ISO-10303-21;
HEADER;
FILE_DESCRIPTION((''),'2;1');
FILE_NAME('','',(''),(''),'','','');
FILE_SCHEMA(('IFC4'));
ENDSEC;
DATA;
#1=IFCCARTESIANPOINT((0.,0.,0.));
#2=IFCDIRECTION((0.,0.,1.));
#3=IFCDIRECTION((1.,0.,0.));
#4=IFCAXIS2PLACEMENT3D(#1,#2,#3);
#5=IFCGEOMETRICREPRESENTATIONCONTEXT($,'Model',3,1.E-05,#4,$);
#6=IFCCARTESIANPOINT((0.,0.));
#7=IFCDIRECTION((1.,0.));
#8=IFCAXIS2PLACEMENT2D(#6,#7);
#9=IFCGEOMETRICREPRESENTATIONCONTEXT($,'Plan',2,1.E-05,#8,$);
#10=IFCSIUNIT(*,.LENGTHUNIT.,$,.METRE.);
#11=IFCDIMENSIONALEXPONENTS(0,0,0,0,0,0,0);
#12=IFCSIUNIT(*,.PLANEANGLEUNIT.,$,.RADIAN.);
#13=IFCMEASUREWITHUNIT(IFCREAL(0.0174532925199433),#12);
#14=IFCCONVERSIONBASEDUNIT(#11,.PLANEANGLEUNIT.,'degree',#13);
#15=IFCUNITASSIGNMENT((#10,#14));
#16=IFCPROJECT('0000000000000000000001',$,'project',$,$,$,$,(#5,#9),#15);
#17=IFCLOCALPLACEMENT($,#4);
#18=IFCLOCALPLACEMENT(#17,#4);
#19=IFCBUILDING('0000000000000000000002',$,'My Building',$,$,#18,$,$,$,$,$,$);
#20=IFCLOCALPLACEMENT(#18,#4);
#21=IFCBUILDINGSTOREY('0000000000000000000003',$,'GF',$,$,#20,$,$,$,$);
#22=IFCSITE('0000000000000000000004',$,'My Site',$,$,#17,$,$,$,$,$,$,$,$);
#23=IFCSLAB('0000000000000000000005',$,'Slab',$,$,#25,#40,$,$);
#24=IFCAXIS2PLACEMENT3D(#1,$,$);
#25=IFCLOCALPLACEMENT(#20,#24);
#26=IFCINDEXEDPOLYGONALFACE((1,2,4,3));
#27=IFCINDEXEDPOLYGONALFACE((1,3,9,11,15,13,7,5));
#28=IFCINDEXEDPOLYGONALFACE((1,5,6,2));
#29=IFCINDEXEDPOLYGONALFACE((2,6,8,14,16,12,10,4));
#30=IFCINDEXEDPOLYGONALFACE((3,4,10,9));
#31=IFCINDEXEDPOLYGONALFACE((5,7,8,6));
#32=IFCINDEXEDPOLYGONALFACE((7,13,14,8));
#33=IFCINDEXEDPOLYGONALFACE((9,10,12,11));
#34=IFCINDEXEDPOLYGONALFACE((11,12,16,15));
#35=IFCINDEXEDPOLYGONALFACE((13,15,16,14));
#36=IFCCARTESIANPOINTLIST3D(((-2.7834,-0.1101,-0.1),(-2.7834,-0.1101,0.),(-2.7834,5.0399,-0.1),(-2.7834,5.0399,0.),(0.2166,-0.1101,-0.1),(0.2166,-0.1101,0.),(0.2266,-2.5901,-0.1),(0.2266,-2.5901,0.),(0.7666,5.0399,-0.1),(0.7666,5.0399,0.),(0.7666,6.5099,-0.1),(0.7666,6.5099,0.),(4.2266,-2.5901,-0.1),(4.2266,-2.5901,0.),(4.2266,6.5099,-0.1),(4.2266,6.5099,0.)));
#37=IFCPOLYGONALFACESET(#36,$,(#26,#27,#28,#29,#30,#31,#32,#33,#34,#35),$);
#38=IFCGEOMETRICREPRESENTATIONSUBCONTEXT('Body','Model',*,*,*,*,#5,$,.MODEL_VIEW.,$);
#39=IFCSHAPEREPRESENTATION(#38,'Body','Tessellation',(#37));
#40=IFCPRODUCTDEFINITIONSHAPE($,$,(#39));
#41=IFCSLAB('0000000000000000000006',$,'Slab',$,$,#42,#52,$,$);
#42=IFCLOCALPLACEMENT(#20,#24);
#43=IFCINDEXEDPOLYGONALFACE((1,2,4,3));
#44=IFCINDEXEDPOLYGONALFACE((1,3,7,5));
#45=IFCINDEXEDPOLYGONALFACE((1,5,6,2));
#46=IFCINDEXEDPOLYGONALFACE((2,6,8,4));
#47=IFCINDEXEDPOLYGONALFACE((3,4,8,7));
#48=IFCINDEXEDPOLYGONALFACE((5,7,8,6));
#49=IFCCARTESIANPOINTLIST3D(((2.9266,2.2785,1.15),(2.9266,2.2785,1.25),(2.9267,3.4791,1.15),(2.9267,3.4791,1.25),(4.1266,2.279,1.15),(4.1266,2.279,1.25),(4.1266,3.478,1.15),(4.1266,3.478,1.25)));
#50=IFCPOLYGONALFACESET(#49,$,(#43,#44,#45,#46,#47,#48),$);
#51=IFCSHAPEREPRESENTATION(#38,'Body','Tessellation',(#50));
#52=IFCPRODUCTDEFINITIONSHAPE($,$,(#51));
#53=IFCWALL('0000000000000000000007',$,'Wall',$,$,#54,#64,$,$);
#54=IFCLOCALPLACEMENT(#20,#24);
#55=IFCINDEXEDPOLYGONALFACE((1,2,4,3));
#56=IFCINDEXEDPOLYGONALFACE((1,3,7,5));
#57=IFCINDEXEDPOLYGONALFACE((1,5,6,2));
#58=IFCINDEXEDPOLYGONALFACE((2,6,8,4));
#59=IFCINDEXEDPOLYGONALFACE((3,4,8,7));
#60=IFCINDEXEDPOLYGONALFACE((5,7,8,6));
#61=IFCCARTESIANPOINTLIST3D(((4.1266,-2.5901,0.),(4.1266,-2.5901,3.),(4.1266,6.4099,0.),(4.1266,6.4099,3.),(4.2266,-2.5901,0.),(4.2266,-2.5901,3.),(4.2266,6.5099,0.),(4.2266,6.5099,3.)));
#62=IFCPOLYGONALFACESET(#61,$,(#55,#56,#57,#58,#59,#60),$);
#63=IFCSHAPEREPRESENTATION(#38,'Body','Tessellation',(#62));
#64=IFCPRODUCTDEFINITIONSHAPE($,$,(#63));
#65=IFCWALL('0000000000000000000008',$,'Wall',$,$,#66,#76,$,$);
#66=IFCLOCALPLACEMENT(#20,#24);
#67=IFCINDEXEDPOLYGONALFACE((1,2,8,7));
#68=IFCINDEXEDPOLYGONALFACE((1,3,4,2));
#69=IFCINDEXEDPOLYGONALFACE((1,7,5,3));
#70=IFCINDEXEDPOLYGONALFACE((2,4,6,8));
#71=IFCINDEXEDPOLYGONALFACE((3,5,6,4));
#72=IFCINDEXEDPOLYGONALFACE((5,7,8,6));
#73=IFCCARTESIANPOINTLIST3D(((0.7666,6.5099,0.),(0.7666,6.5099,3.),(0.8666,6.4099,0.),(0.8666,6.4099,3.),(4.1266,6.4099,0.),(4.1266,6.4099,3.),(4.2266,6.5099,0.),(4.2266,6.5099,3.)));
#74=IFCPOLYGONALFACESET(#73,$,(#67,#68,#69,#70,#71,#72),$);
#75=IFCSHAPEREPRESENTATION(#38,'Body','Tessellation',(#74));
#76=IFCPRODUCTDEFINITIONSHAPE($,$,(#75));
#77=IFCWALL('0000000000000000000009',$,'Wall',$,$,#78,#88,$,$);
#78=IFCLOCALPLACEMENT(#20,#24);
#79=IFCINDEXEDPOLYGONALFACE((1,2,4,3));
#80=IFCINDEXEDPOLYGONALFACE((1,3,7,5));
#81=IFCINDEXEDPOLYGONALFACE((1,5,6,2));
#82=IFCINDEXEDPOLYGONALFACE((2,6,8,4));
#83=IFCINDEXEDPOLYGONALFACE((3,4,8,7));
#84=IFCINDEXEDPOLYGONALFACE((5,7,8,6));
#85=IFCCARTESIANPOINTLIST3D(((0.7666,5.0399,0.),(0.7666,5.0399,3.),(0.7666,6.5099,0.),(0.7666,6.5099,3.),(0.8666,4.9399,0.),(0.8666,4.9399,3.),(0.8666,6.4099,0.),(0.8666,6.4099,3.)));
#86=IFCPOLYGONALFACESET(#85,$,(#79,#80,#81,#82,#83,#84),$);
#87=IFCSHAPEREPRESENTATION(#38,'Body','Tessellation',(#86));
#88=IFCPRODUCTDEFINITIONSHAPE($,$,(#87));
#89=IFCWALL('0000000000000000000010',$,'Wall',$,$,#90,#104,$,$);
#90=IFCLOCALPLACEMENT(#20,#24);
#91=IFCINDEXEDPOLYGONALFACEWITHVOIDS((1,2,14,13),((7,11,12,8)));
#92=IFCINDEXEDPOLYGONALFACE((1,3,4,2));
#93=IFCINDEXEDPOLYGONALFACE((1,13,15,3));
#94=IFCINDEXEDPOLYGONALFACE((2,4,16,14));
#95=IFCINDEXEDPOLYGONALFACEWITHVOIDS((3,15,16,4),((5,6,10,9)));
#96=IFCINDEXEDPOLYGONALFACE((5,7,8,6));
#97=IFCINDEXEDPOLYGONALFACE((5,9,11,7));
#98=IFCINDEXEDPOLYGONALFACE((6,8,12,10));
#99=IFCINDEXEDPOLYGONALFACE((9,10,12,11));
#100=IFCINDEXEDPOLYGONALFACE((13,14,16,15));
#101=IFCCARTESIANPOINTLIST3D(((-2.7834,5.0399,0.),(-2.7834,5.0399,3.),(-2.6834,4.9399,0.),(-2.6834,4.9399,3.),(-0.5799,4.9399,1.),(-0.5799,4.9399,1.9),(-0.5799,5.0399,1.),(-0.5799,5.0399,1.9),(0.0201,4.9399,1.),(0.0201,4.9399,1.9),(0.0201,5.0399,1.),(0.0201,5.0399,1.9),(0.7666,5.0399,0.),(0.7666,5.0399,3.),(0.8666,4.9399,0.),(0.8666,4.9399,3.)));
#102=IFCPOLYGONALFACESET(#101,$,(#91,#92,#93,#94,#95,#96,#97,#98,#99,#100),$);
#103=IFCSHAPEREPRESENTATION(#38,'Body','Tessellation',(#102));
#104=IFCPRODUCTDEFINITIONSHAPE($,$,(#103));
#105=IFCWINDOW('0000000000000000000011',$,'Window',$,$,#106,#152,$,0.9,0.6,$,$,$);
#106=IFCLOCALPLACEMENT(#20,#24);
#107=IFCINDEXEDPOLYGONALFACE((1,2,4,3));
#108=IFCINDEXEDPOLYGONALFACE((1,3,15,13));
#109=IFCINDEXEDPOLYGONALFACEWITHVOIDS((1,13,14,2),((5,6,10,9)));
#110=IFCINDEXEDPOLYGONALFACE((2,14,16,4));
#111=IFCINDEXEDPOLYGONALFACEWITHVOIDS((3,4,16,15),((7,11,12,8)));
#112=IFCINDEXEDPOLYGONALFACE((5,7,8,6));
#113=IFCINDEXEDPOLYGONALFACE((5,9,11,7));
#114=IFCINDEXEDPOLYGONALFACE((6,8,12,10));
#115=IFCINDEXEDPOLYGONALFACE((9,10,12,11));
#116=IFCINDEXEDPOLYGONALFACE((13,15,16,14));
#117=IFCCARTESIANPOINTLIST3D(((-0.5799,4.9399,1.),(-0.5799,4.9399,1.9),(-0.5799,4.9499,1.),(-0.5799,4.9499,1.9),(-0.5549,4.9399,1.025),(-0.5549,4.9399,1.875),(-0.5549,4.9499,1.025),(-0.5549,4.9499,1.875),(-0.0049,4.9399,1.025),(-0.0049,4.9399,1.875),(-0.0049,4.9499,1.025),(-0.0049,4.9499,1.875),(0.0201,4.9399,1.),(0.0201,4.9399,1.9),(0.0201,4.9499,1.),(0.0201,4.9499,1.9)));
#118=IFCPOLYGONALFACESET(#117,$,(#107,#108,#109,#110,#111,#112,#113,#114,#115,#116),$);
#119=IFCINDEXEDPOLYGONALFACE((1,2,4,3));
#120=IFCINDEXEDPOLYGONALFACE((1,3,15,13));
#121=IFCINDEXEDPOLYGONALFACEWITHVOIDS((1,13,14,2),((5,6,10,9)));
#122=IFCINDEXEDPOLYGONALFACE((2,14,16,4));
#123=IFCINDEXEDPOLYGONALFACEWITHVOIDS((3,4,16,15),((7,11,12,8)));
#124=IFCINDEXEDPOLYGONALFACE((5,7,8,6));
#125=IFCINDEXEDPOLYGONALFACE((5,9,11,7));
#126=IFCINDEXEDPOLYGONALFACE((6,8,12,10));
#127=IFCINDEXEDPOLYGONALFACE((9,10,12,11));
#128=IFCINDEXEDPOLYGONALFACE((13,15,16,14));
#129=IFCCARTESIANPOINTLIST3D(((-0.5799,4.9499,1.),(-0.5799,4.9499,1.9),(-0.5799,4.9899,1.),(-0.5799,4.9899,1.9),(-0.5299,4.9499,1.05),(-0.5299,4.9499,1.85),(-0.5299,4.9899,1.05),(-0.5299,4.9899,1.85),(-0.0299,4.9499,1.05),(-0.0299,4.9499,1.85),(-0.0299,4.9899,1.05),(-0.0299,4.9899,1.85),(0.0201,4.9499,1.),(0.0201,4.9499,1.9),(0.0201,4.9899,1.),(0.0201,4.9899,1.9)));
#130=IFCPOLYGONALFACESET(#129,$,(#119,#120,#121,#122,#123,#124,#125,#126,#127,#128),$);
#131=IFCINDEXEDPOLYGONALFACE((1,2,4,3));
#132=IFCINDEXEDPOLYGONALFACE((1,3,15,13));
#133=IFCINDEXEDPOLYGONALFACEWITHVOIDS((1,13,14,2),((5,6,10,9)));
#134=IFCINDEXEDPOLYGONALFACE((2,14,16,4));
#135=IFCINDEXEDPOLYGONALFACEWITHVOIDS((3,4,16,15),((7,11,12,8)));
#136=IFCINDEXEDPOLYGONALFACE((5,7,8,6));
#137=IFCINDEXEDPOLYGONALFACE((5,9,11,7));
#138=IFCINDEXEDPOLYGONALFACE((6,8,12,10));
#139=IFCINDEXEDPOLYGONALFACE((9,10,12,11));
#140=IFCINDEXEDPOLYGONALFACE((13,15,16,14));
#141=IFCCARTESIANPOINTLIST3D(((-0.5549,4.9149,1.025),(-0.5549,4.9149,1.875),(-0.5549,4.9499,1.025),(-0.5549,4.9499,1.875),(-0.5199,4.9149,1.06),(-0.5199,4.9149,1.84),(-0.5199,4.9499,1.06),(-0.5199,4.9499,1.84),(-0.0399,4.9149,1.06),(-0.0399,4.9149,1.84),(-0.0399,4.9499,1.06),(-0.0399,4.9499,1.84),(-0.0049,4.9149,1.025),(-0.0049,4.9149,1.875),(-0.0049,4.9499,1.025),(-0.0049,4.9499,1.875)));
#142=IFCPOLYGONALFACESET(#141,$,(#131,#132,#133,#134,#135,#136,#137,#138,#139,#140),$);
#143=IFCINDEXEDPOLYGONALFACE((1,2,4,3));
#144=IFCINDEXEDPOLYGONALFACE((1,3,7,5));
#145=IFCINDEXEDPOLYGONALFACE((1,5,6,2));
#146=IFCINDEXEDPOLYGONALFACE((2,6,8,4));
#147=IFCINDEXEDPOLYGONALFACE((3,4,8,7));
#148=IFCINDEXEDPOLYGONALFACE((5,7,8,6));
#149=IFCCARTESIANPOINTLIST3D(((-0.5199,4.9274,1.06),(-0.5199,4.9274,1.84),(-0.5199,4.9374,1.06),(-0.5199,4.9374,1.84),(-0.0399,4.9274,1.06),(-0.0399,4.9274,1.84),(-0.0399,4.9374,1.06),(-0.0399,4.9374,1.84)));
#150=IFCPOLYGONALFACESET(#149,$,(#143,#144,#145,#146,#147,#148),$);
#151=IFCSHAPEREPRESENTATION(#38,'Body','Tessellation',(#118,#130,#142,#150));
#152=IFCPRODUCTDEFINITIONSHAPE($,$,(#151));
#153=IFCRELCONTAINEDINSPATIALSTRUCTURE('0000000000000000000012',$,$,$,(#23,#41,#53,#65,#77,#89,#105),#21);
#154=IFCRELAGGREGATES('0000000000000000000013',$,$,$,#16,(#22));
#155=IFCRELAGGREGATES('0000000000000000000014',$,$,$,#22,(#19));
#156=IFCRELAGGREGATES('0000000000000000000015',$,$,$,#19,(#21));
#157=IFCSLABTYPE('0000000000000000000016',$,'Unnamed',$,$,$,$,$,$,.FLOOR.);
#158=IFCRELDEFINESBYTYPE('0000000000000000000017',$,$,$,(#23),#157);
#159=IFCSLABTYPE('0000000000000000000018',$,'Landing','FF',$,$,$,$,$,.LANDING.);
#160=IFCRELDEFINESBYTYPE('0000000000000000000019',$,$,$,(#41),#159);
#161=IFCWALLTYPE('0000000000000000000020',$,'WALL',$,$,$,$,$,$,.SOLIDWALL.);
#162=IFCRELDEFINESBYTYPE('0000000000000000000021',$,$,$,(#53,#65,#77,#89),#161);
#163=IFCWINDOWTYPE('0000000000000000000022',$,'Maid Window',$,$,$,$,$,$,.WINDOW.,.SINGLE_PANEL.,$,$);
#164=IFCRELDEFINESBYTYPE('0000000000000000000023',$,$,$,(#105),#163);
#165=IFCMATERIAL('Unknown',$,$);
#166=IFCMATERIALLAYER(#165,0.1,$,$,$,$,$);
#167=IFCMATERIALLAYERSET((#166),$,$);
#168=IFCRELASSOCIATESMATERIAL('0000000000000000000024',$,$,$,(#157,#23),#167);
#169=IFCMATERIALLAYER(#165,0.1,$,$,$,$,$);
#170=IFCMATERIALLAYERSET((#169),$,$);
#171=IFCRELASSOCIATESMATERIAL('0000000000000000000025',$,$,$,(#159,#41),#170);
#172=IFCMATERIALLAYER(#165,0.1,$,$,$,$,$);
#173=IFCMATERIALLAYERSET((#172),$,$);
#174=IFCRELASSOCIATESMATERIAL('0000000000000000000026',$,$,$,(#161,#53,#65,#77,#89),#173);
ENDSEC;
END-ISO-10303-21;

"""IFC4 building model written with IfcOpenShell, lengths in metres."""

from ifc_helpers import new_model, entity, si_unit, converted_unit, frame, origin_with_axes, origin_2d_with_axis, place, context, subcontext, project, spatial, line, indexed_curve, outline, extrude, shape, source, transform, mapped, material, layer, layer_set, layer_usage, type_object, type_shapes, element, fill, save


model = new_model("IFC4")

# Units and contexts
model_context = context("Model", 3, precision=1e-05, world=origin_with_axes())
plan_context = context("Plan", 2, precision=1e-05, world=origin_2d_with_axis())
body_context_1 = subcontext(model_context, "Body", "Model", "MODEL_VIEW")
body_context_2 = subcontext(plan_context, "Body", "Plan", "PLAN_VIEW")
ifc_project = project(units=[si_unit("LENGTHUNIT", "METRE"), converted_unit("PLANEANGLEUNIT", "degree", entity("IfcReal", 0.0174532925199433), si_unit("PLANEANGLEUNIT", "RADIAN"), dimensions=[0, 0, 0, 0, 0, 0, 0])], contexts=[model_context, plan_context])

# Site, building, storey
site_placement = place(None, origin_with_axes())
site = spatial("IfcSite", under=ifc_project, at=site_placement, Name="My Site")
building_placement = place(site_placement, origin_with_axes())
building = spatial("IfcBuilding", under=site, at=building_placement, Name="My Building")
storey_placement = place(building_placement, origin_with_axes())
storey = spatial("IfcBuildingStorey", under=building, at=storey_placement, Name="GF")

# Slabs
ifc_material_1 = material(Name="Unknown")
ifc_layer_1 = layer(ifc_material_1, 0.1)
ifc_layer_set_1 = layer_set([ifc_layer_1])
ifc_layer_usage_1 = layer_usage(ifc_layer_set_1, "AXIS3", "POSITIVE", -0.1)
slab_type_1 = type_object("IfcSlabType", Name="Unnamed", PredefinedType="FLOOR", material=ifc_layer_set_1)
slab_1_placement = place(storey_placement, frame((4.2266, -2.5901, 0.0), z_axis=(0.0, 0.0, 1.0), x_axis=(1.0, 0.0, 0.0)))
element("IfcSlab", 1, at=slab_1_placement, inside=storey, type_object=slab_type_1, material=ifc_layer_usage_1, Name="Slab", context=body_context_1, shape_type="SweptSolid", body=[
    extrude(outline(indexed_curve([(0.0, 0.0), (0.0, 9.1), (-3.46, 9.1), (-3.46, 7.63), (-7.01, 7.63), (-7.01, 2.48), (-4.01, 2.48), (-4.0, 0.0), (0.0, 0.0)])), frame((0.0, 0.0, -0.1), z_axis=(0.0, 0.0, 1.0), x_axis=(1.0, 0.0, 0.0)), (0.0, 0.0, 1.0), 0.1),
])
ifc_layer_2 = layer(ifc_material_1, 0.1)
ifc_layer_set_2 = layer_set([ifc_layer_2])
ifc_layer_usage_2 = layer_usage(ifc_layer_set_2, "AXIS3", "POSITIVE", -0.1)
slab_type_2 = type_object("IfcSlabType", Name="Landing", Description="FF", PredefinedType="LANDING", material=ifc_layer_set_2)
slab_2_placement = place(storey_placement, frame((2.9266, 2.2785, 1.25), z_axis=(0.0, 0.0, 1.0), x_axis=(1.0, 0.0, 0.0)))
element("IfcSlab", 2, at=slab_2_placement, inside=storey, type_object=slab_type_2, material=ifc_layer_usage_2, Name="Slab", context=body_context_1, shape_type="SweptSolid", body=[
    extrude(outline(indexed_curve([(0.0, 0.0), (1.2, 0.0005), (1.2, 1.1995), (0.0001, 1.2006), (0.0, 0.0)])), frame((0.0, 0.0, -0.1), z_axis=(0.0, 0.0, 1.0), x_axis=(1.0, 0.0, 0.0)), (0.0, 0.0, 1.0), 0.1),
])

# Shared definitions
ifc_layer_3 = layer(ifc_material_1, 0.1)
ifc_layer_set_3 = layer_set([ifc_layer_3])
wall_type = type_object("IfcWallType", Name="WALL", PredefinedType="SOLIDWALL", material=ifc_layer_set_3)

# Walls
ifc_layer_usage_3 = layer_usage(ifc_layer_set_3, "AXIS2", "POSITIVE", 0.0)
wall_1_placement = place(storey_placement, frame((4.2266, -2.5901, 0.0), z_axis=(0.0, 0.0, 1.0), x_axis=(0.0, 1.0, 0.0)))
element("IfcWall", 3, at=wall_1_placement, inside=storey, type_object=wall_type, material=ifc_layer_usage_3, Name="Wall", context=body_context_1, shape_type="SweptSolid", body=[
    extrude(outline(indexed_curve([(0.0, 0.0), (0.0, 0.1), (9.0, 0.1), (9.1, 0.0)], segments=[line(1, 2, 3, 4, 1)])), origin_with_axes(), (0.0, 0.0, 1.0), 3.0),
])
ifc_layer_usage_4 = layer_usage(ifc_layer_set_3, "AXIS2", "POSITIVE", 0.0)
wall_2_placement = place(storey_placement, frame((4.2266, 6.5099, 0.0), z_axis=(0.0, 0.0, 1.0), x_axis=(-1.0, 0.0, 0.0)))
element("IfcWall", 4, at=wall_2_placement, inside=storey, type_object=wall_type, material=ifc_layer_usage_4, Name="Wall", context=body_context_1, shape_type="SweptSolid", body=[
    extrude(outline(indexed_curve([(0.0, 0.0), (0.1, 0.1), (3.36, 0.1), (3.46, 0.0)], segments=[line(1, 2, 3, 4, 1)])), origin_with_axes(), (0.0, 0.0, 1.0), 3.0),
])
ifc_layer_usage_5 = layer_usage(ifc_layer_set_3, "AXIS2", "POSITIVE", 0.0)
wall_3_placement = place(storey_placement, frame((0.7666, 6.5099, 0.0), z_axis=(0.0, 0.0, 1.0), x_axis=(0.0, -1.0, 0.0)))
element("IfcWall", 5, at=wall_3_placement, inside=storey, type_object=wall_type, material=ifc_layer_usage_5, Name="Wall", context=body_context_1, shape_type="SweptSolid", body=[
    extrude(outline(indexed_curve([(0.0, 0.0), (0.1, 0.1), (1.57, 0.1), (1.47, 0.0)], segments=[line(1, 2, 3, 4, 1)])), origin_with_axes(), (0.0, 0.0, 1.0), 3.0),
])

# Wall, opening, window
ifc_layer_usage_6 = layer_usage(ifc_layer_set_3, "AXIS2", "POSITIVE", 0.0)
wall_4_placement = place(storey_placement, frame((0.7666, 5.0399, 0.0), z_axis=(0.0, 0.0, 1.0), x_axis=(-1.0, 0.0, 0.0)))
wall_4 = element("IfcWall", 6, at=wall_4_placement, inside=storey, type_object=wall_type, material=ifc_layer_usage_6, Name="Wall", context=body_context_1, shape_type="SweptSolid", body=[
    extrude(outline(indexed_curve([(0.0, 0.0), (-0.1, 0.1), (3.45, 0.1), (3.55, 0.0)], segments=[line(1, 2, 3, 4, 1)])), origin_with_axes(), (0.0, 0.0, 1.0), 3.0),
])
shared_shape_1 = source(origin_with_axes(), body_context_1, "Body", "SweptSolid", [
    extrude(outline(indexed_curve([(0.0, 0.0), (0.6, 0.0), (0.6, 0.9), (0.0, 0.9)], segments=[line(1, 2, 3, 4, 1)])), frame((0.0, -0.6, 0.0), z_axis=(0.0, -1.0, 0.0), x_axis=(1.0, 0.0, 0.0)), (0.0, 0.0, -1.0), 1.2),
])
opening_1_placement = place(wall_4_placement, frame((0.7465, 0.0, 1.0), z_axis=(0.0, 0.0, 1.0), x_axis=(1.0, 0.0, 0.0)))
opening_1 = element("IfcOpeningElement", 7, at=opening_1_placement, cuts=wall_4, PredefinedType="OPENING", context=body_context_1, shape_type="MappedRepresentation", body=[
    mapped(shared_shape_1, transform((0.0, 0.0, 0.0), x_axis=(1.0, 0.0, 0.0), y_axis=(0.0, 1.0, 0.0), z_axis=(0.0, 0.0, 1.0), scale=1.0)),
])
window_type_1 = type_object("IfcWindowType", Name="Maid Window", PartitioningType="SINGLE_PANEL", PredefinedType="WINDOW")
shared_shape_2 = source(origin_with_axes(), body_context_1, "Body", "SweptSolid", [
    extrude(outline(indexed_curve([(0.0, 0.0), (0.6, 0.0), (0.6, 0.9), (0.0, 0.9)], segments=[line(1, 2, 3, 4, 1)]), holes=[indexed_curve([(0.025, 0.025), (0.575, 0.025), (0.575, 0.875), (0.025, 0.875)], segments=[line(1, 2, 3, 4, 1)])]), frame((0.0, 0.09, 0.0), z_axis=(0.0, -1.0, 0.0), x_axis=(1.0, 0.0, 0.0)), (0.0, 0.0, -1.0), 0.01),
    extrude(outline(indexed_curve([(0.0, 0.0), (0.6, 0.0), (0.6, 0.9), (0.0, 0.9)], segments=[line(1, 2, 3, 4, 1)]), holes=[indexed_curve([(0.05, 0.05), (0.55, 0.05), (0.55, 0.85), (0.05, 0.85)], segments=[line(1, 2, 3, 4, 1)])]), frame((0.0, 0.05, 0.0), z_axis=(0.0, -1.0, 0.0), x_axis=(1.0, 0.0, 0.0)), (0.0, 0.0, -1.0), 0.04),
    extrude(outline(indexed_curve([(0.0, 0.0), (0.55, 0.0), (0.55, 0.85), (0.0, 0.85)], segments=[line(1, 2, 3, 4, 1)]), holes=[indexed_curve([(0.035, 0.035), (0.515, 0.035), (0.515, 0.815), (0.035, 0.815)], segments=[line(1, 2, 3, 4, 1)])]), frame((0.025, 0.09, 0.025), z_axis=(0.0, -1.0, 0.0), x_axis=(1.0, 0.0, 0.0)), (0.0, 0.0, -1.0), 0.035),
    extrude(outline(indexed_curve([(0.035, 0.035), (0.515, 0.035), (0.515, 0.815), (0.035, 0.815)], segments=[line(1, 2, 3, 4, 1)])), frame((0.025, 0.1025, 0.025), z_axis=(0.0, -1.0, 0.0), x_axis=(1.0, 0.0, 0.0)), (0.0, 0.0, -1.0), 0.01),
])
shared_shape_3 = source(origin_with_axes(), body_context_2, "Body", "Curve2D", [
    entity("IfcIndexedPolyCurve", entity("IfcCartesianPointList2D", [[0.05, 0.05], [0.55, 0.05]])),
    entity("IfcIndexedPolyCurve", entity("IfcCartesianPointList2D", [[0.0, 0.1], [0.025, 0.1], [0.025, 0.09], [0.05, 0.09], [0.05, 0.05], [0.0, 0.05]]), [entity("IfcLineIndex", [1, 2, 3, 4, 5, 6, 1])]),
    entity("IfcIndexedPolyCurve", entity("IfcCartesianPointList2D", [[0.6, 0.1], [0.575, 0.1], [0.575, 0.09], [0.55, 0.09], [0.55, 0.05], [0.6, 0.05]]), [entity("IfcLineIndex", [1, 2, 3, 4, 5, 6, 1])]),
    entity("IfcIndexedPolyCurve", entity("IfcCartesianPointList2D", [[0.025, 0.09], [0.06, 0.09], [0.06, 0.125], [0.025, 0.125]]), [entity("IfcLineIndex", [1, 2, 3, 4, 1])]),
    entity("IfcIndexedPolyCurve", entity("IfcCartesianPointList2D", [[0.575, 0.09], [0.54, 0.09], [0.54, 0.125], [0.575, 0.125]]), [entity("IfcLineIndex", [1, 2, 3, 4, 1])]),
    entity("IfcIndexedPolyCurve", entity("IfcCartesianPointList2D", [[0.06, 0.09], [0.54, 0.09]])),
    entity("IfcIndexedPolyCurve", entity("IfcCartesianPointList2D", [[0.06, 0.125], [0.54, 0.125]])),
    entity("IfcIndexedPolyCurve", entity("IfcCartesianPointList2D", [[0.06, 0.1075], [0.54, 0.1075]])),
])
type_shapes(window_type_1, [shared_shape_2, shared_shape_3])
window_1_placement = place(opening_1_placement, frame((0.0, 0.0, 0.0), z_axis=(0.0, 0.0, 1.0), x_axis=(1.0, 0.0, 0.0)))
window_1 = element("IfcWindow", 8, at=window_1_placement, inside=storey, type_object=window_type_1, Name="Window", OverallHeight=0.9, OverallWidth=0.6, shapes=[
    shape(body_context_1, "Body", "MappedRepresentation", [mapped(shared_shape_2, transform((0.0, 0.0, 0.0), x_axis=(1.0, 0.0, 0.0), y_axis=(0.0, 1.0, 0.0), z_axis=(0.0, 0.0, 1.0), scale=1.0))]),
    shape(body_context_2, "Body", "MappedRepresentation", [mapped(shared_shape_3, transform((0.0, 0.0, 0.0), x_axis=(1.0, 0.0, 0.0), y_axis=(0.0, 1.0, 0.0), z_axis=(0.0, 0.0, 1.0), scale=1.0))]),
])
fill(opening_1, window_1)

save(model, "model.ifc")
